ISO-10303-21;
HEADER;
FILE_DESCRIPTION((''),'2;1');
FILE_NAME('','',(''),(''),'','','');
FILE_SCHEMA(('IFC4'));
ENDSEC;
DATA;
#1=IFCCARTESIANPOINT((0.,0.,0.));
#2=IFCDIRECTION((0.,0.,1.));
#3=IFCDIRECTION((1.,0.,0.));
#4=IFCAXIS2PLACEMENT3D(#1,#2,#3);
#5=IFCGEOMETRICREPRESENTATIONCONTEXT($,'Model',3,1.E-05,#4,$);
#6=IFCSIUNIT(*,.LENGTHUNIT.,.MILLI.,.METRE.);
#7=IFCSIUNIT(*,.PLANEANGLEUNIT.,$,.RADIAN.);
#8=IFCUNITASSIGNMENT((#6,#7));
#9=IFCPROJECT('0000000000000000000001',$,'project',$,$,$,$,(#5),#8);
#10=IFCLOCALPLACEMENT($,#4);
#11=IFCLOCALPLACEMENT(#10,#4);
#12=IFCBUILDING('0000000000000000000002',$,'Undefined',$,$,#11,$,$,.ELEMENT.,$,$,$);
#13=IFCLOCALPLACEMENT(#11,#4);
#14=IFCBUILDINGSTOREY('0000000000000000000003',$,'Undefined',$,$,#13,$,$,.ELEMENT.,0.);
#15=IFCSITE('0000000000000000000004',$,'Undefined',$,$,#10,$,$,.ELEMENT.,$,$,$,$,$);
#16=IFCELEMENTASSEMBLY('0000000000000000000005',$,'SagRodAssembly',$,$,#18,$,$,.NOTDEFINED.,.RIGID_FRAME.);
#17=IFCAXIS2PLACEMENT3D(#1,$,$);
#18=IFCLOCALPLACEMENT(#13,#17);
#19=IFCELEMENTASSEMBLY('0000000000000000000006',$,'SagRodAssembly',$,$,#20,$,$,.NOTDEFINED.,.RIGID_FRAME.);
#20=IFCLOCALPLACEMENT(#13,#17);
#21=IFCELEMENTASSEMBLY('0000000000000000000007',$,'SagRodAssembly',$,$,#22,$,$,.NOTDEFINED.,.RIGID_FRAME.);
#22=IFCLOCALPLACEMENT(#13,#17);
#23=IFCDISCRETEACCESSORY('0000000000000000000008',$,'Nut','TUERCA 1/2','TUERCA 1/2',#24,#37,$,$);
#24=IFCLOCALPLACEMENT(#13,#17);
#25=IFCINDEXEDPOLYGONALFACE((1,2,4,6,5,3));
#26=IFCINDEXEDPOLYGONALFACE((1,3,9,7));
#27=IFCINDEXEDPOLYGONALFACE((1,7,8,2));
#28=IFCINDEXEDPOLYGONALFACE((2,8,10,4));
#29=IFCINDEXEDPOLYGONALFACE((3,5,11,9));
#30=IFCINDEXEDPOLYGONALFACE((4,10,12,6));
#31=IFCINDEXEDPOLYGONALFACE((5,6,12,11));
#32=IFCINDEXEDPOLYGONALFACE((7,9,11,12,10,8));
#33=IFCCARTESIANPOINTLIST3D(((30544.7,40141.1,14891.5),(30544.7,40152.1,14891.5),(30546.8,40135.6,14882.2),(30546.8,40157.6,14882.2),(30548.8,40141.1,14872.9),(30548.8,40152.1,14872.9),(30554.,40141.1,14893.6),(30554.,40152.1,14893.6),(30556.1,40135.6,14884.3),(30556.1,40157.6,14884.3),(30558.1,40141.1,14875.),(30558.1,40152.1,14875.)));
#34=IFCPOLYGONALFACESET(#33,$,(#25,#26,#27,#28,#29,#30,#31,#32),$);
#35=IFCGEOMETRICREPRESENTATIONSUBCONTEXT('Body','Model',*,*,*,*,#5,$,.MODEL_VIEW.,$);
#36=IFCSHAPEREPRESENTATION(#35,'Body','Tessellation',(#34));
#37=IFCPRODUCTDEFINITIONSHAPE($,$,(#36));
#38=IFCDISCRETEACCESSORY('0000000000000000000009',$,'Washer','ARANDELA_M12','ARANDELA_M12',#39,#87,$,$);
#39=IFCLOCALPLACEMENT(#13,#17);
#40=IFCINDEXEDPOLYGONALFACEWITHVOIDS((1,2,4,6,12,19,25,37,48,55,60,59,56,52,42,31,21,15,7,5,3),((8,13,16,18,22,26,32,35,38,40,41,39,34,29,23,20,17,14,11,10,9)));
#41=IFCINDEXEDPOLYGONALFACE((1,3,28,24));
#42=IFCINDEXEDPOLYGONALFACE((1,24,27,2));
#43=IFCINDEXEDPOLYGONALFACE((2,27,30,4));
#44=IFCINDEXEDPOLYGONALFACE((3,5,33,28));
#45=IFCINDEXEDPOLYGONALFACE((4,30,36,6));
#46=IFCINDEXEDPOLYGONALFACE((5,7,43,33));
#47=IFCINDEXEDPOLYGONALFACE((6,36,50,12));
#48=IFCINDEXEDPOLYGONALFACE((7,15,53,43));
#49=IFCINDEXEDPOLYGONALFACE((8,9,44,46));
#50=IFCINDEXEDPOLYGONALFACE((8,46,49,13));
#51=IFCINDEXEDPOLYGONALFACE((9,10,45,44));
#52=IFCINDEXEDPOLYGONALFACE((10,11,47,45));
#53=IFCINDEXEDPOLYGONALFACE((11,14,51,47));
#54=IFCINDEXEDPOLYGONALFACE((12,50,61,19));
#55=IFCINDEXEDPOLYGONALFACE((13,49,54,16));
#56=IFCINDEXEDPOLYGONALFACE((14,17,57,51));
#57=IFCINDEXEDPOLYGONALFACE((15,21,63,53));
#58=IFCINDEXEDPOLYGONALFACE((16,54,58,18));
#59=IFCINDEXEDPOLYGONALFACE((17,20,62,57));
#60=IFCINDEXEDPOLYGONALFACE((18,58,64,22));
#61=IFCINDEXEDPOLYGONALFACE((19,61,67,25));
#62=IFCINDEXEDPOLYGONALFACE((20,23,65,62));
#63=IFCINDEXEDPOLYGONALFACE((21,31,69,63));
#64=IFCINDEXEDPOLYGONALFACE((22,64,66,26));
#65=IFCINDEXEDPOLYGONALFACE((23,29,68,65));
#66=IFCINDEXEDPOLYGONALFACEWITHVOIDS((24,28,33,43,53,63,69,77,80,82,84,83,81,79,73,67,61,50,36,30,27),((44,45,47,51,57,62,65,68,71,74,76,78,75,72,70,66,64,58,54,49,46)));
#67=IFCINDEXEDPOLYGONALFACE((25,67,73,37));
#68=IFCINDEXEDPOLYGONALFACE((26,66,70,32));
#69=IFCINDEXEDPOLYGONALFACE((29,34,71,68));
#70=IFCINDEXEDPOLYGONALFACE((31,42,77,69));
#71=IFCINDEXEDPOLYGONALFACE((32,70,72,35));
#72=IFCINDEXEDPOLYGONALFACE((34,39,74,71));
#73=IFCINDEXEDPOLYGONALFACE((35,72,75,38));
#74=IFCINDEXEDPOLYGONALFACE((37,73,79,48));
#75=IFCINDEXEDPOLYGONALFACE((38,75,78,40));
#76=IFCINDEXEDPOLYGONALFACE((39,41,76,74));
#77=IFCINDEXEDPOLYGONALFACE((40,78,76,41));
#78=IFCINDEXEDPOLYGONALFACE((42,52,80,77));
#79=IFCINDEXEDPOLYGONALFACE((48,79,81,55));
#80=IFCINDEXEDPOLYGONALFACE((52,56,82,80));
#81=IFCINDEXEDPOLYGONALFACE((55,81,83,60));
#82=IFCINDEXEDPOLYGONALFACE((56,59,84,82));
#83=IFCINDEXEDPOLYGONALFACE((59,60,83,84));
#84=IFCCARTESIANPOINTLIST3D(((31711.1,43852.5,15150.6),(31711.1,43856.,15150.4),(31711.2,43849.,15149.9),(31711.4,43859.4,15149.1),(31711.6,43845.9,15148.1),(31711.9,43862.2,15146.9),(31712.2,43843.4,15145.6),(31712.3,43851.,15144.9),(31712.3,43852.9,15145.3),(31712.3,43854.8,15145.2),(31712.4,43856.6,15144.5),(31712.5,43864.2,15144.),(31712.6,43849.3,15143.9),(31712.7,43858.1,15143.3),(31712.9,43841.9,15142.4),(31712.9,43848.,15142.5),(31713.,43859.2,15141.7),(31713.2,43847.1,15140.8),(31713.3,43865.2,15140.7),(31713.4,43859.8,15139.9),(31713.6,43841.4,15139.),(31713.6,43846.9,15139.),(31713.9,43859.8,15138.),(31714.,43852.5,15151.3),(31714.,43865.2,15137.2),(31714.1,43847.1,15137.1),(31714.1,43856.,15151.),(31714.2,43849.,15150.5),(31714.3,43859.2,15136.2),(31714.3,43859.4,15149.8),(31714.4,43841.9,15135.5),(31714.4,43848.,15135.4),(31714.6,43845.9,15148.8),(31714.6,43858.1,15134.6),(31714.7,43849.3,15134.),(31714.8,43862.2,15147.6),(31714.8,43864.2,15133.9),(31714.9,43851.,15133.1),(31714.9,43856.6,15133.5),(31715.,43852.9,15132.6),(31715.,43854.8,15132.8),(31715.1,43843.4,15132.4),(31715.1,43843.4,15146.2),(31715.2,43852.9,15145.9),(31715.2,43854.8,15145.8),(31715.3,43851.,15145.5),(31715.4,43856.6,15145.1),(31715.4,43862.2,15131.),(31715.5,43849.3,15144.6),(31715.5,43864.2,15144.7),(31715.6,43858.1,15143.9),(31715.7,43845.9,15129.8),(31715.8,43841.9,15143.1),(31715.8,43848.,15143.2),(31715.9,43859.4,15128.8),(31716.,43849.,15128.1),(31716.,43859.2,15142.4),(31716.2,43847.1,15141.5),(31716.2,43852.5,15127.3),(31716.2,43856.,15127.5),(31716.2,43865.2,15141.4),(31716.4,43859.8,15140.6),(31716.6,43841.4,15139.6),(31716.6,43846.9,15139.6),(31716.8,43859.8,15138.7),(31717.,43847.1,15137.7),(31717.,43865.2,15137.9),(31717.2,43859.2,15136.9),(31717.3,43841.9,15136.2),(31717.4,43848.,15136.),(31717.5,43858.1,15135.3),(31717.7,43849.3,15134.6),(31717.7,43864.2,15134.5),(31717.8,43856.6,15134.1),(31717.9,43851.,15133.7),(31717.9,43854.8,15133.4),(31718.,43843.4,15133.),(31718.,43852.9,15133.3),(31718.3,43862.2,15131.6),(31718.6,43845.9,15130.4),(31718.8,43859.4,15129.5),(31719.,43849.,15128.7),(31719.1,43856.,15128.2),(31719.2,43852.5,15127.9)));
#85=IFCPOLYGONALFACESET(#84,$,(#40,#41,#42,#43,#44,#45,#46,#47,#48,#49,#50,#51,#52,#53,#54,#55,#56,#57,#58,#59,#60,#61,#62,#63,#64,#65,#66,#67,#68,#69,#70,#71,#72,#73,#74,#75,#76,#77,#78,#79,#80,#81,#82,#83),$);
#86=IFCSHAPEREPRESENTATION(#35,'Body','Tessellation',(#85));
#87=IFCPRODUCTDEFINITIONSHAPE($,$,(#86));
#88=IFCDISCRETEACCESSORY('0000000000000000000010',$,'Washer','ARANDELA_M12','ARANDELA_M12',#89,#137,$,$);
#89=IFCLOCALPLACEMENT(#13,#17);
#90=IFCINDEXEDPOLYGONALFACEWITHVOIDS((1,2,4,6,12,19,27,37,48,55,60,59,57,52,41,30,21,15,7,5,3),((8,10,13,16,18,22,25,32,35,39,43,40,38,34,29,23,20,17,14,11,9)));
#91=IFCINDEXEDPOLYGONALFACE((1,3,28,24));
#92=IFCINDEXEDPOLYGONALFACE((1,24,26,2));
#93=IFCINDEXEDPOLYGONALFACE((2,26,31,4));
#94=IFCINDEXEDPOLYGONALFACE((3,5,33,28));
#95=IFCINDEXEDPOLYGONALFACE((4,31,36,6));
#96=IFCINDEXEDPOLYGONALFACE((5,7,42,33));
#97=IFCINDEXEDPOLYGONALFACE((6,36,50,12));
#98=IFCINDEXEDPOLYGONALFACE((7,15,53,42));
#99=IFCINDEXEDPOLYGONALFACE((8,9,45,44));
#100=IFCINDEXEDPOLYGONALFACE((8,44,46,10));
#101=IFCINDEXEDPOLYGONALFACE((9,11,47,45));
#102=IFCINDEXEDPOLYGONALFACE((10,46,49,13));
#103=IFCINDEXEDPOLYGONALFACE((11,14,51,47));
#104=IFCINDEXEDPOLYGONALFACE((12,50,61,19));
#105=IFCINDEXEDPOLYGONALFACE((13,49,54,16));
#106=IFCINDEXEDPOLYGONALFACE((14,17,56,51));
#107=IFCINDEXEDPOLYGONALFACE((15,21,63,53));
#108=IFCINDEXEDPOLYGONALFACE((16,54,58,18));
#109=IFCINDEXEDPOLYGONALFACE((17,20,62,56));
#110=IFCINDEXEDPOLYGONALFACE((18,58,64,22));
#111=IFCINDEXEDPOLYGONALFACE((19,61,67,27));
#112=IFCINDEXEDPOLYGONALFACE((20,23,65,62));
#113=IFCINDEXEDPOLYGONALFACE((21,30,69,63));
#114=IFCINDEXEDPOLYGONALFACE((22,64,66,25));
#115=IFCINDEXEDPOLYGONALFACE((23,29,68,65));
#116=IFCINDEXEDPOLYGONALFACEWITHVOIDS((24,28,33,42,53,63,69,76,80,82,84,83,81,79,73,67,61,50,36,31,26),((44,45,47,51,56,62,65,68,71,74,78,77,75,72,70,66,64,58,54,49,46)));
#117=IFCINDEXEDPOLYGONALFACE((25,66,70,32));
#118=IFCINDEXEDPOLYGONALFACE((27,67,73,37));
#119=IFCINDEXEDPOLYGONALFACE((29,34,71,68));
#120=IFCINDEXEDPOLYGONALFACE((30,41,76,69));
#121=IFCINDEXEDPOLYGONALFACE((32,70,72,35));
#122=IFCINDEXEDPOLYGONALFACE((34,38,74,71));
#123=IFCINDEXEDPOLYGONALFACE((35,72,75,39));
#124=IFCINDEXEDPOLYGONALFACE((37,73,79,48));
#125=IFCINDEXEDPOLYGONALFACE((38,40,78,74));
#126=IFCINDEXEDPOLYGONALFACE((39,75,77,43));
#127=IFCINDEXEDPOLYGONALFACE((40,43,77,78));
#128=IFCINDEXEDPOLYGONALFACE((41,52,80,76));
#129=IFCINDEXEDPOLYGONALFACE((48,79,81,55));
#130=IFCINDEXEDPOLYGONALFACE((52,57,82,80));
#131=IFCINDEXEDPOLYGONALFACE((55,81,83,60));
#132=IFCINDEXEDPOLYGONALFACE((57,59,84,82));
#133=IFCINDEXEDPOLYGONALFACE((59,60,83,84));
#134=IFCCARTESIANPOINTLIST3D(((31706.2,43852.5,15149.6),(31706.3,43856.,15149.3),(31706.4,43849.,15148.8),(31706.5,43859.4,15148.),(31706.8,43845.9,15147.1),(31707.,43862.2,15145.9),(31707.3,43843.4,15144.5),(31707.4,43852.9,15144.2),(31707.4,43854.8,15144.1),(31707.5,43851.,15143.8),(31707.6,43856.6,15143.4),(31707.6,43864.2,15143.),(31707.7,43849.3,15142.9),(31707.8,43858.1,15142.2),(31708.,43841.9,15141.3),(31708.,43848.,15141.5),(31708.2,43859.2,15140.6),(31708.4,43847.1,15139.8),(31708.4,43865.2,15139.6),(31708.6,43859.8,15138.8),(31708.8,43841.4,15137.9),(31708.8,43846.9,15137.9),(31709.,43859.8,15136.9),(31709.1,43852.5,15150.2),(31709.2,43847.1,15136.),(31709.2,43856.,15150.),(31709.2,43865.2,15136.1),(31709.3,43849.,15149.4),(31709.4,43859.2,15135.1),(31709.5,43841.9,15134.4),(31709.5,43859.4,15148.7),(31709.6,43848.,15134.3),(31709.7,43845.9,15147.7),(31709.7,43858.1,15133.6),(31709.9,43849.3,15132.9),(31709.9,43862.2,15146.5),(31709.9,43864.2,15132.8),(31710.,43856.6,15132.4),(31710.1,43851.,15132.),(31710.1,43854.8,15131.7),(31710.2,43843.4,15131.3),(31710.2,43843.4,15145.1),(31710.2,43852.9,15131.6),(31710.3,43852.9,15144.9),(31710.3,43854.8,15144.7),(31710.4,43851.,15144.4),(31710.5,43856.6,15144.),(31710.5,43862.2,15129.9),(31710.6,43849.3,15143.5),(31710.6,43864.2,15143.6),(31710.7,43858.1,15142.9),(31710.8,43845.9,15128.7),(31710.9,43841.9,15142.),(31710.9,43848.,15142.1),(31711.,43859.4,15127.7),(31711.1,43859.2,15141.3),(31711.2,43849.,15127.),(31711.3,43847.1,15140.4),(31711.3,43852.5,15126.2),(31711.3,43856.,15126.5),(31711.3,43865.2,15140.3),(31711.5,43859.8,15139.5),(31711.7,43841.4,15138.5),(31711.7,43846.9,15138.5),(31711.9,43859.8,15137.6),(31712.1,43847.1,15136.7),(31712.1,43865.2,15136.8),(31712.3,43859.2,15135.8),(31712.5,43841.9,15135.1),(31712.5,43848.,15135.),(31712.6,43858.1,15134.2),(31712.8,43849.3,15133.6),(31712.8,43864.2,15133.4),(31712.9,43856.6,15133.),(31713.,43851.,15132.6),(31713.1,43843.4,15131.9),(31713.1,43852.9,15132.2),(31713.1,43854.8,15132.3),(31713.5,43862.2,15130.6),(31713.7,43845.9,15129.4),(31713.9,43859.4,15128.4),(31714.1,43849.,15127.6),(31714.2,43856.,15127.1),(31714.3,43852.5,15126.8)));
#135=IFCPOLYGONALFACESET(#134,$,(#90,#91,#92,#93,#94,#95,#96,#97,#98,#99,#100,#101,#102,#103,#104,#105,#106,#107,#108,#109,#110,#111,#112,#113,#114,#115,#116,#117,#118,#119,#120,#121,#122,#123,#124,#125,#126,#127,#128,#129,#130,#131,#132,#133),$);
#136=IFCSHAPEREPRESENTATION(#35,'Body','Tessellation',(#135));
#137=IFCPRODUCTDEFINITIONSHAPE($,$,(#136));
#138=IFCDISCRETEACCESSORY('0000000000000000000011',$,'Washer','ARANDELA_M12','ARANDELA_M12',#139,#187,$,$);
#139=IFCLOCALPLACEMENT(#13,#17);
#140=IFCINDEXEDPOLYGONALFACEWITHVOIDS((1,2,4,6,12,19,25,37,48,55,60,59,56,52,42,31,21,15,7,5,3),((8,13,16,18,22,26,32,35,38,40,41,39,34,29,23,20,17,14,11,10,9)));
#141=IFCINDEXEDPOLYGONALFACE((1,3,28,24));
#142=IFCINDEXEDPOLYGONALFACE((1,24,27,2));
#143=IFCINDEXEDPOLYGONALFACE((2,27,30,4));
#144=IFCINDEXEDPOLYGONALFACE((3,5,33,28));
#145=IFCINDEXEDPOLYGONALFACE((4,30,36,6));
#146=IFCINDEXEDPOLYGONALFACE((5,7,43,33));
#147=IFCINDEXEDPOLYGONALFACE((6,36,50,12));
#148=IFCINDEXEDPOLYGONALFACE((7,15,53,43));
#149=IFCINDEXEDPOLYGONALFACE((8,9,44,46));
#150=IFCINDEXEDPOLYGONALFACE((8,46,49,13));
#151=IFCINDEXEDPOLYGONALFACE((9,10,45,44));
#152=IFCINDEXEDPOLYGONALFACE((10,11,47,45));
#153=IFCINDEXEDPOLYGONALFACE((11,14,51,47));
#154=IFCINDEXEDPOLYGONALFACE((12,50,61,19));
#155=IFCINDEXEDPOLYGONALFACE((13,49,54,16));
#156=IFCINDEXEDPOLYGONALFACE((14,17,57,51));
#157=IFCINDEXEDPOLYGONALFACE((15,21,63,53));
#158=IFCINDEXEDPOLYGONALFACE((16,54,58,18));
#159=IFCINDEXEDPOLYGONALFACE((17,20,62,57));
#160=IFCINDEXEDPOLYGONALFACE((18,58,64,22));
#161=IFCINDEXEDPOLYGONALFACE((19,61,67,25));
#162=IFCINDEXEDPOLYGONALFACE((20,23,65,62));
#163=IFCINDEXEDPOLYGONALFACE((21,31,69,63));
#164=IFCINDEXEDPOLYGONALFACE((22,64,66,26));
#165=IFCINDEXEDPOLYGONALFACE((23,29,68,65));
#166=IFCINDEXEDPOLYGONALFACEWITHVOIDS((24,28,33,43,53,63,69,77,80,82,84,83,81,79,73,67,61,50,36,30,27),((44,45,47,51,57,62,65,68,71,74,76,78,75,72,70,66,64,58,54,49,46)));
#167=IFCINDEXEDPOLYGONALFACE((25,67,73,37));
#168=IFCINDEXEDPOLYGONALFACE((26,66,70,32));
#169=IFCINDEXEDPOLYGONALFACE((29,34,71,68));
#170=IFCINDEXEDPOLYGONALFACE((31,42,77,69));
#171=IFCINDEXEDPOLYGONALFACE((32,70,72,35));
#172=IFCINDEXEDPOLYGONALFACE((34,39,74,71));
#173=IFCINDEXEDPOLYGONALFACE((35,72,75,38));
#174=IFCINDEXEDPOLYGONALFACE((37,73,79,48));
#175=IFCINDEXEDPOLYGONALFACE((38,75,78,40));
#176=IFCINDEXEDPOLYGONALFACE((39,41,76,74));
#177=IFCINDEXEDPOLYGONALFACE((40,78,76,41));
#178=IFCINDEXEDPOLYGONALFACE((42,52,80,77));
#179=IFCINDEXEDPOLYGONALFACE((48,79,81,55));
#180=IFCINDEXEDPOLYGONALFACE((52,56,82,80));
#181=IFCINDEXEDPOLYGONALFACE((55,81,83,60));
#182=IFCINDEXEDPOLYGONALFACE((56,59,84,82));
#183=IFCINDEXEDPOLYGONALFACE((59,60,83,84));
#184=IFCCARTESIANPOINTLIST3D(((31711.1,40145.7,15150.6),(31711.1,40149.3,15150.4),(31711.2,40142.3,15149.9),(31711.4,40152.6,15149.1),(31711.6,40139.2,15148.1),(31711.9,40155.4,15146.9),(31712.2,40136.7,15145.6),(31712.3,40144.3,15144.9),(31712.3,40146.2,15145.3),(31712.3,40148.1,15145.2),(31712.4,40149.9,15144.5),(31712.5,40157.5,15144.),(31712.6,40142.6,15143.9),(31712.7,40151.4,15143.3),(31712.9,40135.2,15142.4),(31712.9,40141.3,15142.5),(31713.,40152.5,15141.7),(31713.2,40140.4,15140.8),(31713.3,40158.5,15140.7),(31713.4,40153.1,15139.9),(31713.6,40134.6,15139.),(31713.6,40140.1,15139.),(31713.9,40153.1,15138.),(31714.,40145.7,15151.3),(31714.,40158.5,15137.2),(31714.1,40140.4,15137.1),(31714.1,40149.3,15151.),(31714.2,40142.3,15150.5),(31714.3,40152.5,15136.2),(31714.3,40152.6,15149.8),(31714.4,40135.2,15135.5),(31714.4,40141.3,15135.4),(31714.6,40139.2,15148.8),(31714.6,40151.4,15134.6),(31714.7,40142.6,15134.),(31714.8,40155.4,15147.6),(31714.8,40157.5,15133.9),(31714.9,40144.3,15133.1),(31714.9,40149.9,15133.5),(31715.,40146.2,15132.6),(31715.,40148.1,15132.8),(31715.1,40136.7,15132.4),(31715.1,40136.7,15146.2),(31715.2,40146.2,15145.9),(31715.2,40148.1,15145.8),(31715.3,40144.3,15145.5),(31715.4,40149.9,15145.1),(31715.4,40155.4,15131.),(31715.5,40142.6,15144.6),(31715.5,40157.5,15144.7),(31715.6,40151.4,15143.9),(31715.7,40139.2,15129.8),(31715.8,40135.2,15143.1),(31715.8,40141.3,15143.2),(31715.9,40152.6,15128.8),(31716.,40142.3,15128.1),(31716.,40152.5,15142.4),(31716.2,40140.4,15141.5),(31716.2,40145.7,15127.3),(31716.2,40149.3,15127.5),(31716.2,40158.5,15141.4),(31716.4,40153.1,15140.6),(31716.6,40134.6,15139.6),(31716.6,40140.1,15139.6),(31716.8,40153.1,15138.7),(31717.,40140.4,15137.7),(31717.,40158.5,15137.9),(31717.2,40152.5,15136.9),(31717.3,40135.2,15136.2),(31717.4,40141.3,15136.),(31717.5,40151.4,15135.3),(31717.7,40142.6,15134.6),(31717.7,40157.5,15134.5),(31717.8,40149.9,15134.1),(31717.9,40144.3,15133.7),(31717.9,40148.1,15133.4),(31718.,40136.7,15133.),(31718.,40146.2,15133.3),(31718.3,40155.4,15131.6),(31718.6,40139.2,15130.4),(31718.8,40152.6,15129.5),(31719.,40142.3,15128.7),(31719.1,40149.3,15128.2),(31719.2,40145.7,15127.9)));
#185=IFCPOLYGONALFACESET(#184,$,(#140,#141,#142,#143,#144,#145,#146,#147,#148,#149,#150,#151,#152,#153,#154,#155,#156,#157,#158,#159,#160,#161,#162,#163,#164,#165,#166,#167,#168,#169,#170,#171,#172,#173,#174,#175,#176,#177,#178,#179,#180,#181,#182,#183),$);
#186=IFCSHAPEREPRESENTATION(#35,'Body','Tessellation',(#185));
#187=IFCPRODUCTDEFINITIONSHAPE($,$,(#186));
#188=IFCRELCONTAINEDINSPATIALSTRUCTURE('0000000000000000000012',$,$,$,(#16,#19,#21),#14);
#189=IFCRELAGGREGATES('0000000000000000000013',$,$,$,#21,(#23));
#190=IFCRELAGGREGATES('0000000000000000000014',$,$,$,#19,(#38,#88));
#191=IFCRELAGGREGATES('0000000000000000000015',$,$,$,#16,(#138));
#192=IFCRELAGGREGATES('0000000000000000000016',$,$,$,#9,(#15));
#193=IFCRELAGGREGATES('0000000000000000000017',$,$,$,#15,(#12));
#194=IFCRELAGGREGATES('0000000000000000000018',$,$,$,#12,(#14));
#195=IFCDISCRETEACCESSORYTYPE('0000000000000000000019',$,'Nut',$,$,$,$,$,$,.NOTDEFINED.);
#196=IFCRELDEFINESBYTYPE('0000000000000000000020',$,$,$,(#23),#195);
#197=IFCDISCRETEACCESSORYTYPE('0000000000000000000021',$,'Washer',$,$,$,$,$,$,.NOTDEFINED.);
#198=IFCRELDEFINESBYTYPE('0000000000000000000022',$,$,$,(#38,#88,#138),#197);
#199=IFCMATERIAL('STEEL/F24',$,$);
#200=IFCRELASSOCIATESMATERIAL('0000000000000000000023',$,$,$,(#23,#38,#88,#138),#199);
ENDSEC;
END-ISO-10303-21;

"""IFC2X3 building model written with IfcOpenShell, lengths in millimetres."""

from ifc_helpers import new_model, si_unit, frame, origin_with_axes, origin_2d_with_axis, place, context, subcontext, project, spatial, polyline, hollow_circle, outline, extrude, material, type_object, element, aggregate, save


model = new_model("IFC2X3")

# Units and contexts
model_context = context("Model", 3, precision=1e-05, world=origin_with_axes())
body_context = subcontext(model_context, "Body", "Model", "MODEL_VIEW")
ifc_project = project(units=[si_unit("LENGTHUNIT", "METRE", prefix="MILLI"), si_unit("PLANEANGLEUNIT", "RADIAN")], contexts=[model_context])

# Site, building, storey
site_placement = place(None, origin_with_axes())
site = spatial("IfcSite", under=ifc_project, at=site_placement, Name="Undefined", CompositionType="ELEMENT")
building_placement = place(site_placement, origin_with_axes())
building = spatial("IfcBuilding", under=site, at=building_placement, Name="Undefined", CompositionType="ELEMENT")
storey_placement = place(building_placement, origin_with_axes())
storey = spatial("IfcBuildingStorey", under=building, at=storey_placement, Name="Undefined", CompositionType="ELEMENT", Elevation=0.0)

# Element assembly
assembly_1_placement = place(storey_placement, origin_with_axes())
assembly_1 = element("IfcElementAssembly", 1, at=assembly_1_placement, inside=storey, Name="SagRodAssembly", AssemblyPlace="NOTDEFINED", PredefinedType="RIGID_FRAME")
ifc_material_1 = material(Name="STEEL/F24")

# Element assembly
assembly_2_placement = place(storey_placement, origin_with_axes())
assembly_2 = element("IfcElementAssembly", 2, at=assembly_2_placement, inside=storey, Name="SagRodAssembly", AssemblyPlace="NOTDEFINED", PredefinedType="RIGID_FRAME")
discrete_accessory_type_1 = type_object("IfcDiscreteAccessoryType", Name="Nut")

# Element assembly, discrete accessory
assembly_3_placement = place(storey_placement, origin_with_axes())
assembly_3 = element("IfcElementAssembly", 3, at=assembly_3_placement, inside=storey, Name="SagRodAssembly", AssemblyPlace="NOTDEFINED", PredefinedType="RIGID_FRAME")
discrete_accessory_1_placement = place(assembly_3_placement, frame((30546.8, 40146.6, 14882.2), z_axis=(-0.214887, 0.0, 0.976639), x_axis=(0.976639, 0.0, 0.214887)))
discrete_accessory_1 = element("IfcDiscreteAccessory", 4, at=discrete_accessory_1_placement, type_object=discrete_accessory_type_1, material=ifc_material_1, Name="Nut", Description="TUERCA 1/2", ObjectType="TUERCA 1/2", context=body_context, shape_type="SweptSolid", body=[
    extrude(outline(polyline([(-5.5, 9.5), (5.5, 9.5), (11.0, 0.0), (5.5, -9.5), (-5.5, -9.5), (-11.0, 0.0), (-5.5, 9.5)])), frame((9.5, 0.0, 0.0), z_axis=(-1.0, 0.0, 0.0), x_axis=(0.0, -1.0, 0.0)), (0.0, 0.0, 1.0), 9.5),
])
aggregate(assembly_3, [discrete_accessory_1])

# Discrete accessories
discrete_accessory_type_2 = type_object("IfcDiscreteAccessoryType", Name="Washer")
discrete_accessory_2_placement = place(assembly_2_placement, frame((31713.6, 43853.4, 15139.0), z_axis=(-0.214887, 0.0, 0.976639), x_axis=(0.976639, 0.0, 0.214887)))
discrete_accessory_2 = element("IfcDiscreteAccessory", 5, at=discrete_accessory_2_placement, type_object=discrete_accessory_type_2, material=ifc_material_1, Name="Washer", Description="ARANDELA_M12", ObjectType="ARANDELA_M12", context=body_context, shape_type="SweptSolid", body=[
    extrude(hollow_circle(Radius=12.0, WallThickness=5.5, at=origin_2d_with_axis()), frame((3.0, 0.0, 0.0), z_axis=(-1.0, 0.0, 0.0), x_axis=(0.0, -1.0, 0.0)), (0.0, 0.0, 1.0), 3.0),
])
discrete_accessory_3_placement = place(assembly_2_placement, frame((31708.8, 43853.4, 15137.9), z_axis=(-0.214887, 0.0, 0.976639), x_axis=(0.976639, 0.0, 0.214887)))
discrete_accessory_3 = element("IfcDiscreteAccessory", 6, at=discrete_accessory_3_placement, type_object=discrete_accessory_type_2, material=ifc_material_1, Name="Washer", Description="ARANDELA_M12", ObjectType="ARANDELA_M12", context=body_context, shape_type="SweptSolid", body=[
    extrude(hollow_circle(Radius=12.0, WallThickness=5.5, at=origin_2d_with_axis()), frame((3.0, 0.0, 0.0), z_axis=(-1.0, 0.0, 0.0), x_axis=(0.0, -1.0, 0.0)), (0.0, 0.0, 1.0), 3.0),
])
aggregate(assembly_2, [discrete_accessory_2, discrete_accessory_3])
discrete_accessory_4_placement = place(assembly_1_placement, frame((31713.6, 40146.6, 15139.0), z_axis=(-0.214887, 0.0, 0.976639), x_axis=(0.976639, 0.0, 0.214887)))
discrete_accessory_4 = element("IfcDiscreteAccessory", 7, at=discrete_accessory_4_placement, type_object=discrete_accessory_type_2, material=ifc_material_1, Name="Washer", Description="ARANDELA_M12", ObjectType="ARANDELA_M12", context=body_context, shape_type="SweptSolid", body=[
    extrude(hollow_circle(Radius=12.0, WallThickness=5.5, at=origin_2d_with_axis()), frame((3.0, 0.0, 0.0), z_axis=(-1.0, 0.0, 0.0), x_axis=(0.0, -1.0, 0.0)), (0.0, 0.0, 1.0), 3.0),
])
aggregate(assembly_1, [discrete_accessory_4])

save(model, "model.ifc")
